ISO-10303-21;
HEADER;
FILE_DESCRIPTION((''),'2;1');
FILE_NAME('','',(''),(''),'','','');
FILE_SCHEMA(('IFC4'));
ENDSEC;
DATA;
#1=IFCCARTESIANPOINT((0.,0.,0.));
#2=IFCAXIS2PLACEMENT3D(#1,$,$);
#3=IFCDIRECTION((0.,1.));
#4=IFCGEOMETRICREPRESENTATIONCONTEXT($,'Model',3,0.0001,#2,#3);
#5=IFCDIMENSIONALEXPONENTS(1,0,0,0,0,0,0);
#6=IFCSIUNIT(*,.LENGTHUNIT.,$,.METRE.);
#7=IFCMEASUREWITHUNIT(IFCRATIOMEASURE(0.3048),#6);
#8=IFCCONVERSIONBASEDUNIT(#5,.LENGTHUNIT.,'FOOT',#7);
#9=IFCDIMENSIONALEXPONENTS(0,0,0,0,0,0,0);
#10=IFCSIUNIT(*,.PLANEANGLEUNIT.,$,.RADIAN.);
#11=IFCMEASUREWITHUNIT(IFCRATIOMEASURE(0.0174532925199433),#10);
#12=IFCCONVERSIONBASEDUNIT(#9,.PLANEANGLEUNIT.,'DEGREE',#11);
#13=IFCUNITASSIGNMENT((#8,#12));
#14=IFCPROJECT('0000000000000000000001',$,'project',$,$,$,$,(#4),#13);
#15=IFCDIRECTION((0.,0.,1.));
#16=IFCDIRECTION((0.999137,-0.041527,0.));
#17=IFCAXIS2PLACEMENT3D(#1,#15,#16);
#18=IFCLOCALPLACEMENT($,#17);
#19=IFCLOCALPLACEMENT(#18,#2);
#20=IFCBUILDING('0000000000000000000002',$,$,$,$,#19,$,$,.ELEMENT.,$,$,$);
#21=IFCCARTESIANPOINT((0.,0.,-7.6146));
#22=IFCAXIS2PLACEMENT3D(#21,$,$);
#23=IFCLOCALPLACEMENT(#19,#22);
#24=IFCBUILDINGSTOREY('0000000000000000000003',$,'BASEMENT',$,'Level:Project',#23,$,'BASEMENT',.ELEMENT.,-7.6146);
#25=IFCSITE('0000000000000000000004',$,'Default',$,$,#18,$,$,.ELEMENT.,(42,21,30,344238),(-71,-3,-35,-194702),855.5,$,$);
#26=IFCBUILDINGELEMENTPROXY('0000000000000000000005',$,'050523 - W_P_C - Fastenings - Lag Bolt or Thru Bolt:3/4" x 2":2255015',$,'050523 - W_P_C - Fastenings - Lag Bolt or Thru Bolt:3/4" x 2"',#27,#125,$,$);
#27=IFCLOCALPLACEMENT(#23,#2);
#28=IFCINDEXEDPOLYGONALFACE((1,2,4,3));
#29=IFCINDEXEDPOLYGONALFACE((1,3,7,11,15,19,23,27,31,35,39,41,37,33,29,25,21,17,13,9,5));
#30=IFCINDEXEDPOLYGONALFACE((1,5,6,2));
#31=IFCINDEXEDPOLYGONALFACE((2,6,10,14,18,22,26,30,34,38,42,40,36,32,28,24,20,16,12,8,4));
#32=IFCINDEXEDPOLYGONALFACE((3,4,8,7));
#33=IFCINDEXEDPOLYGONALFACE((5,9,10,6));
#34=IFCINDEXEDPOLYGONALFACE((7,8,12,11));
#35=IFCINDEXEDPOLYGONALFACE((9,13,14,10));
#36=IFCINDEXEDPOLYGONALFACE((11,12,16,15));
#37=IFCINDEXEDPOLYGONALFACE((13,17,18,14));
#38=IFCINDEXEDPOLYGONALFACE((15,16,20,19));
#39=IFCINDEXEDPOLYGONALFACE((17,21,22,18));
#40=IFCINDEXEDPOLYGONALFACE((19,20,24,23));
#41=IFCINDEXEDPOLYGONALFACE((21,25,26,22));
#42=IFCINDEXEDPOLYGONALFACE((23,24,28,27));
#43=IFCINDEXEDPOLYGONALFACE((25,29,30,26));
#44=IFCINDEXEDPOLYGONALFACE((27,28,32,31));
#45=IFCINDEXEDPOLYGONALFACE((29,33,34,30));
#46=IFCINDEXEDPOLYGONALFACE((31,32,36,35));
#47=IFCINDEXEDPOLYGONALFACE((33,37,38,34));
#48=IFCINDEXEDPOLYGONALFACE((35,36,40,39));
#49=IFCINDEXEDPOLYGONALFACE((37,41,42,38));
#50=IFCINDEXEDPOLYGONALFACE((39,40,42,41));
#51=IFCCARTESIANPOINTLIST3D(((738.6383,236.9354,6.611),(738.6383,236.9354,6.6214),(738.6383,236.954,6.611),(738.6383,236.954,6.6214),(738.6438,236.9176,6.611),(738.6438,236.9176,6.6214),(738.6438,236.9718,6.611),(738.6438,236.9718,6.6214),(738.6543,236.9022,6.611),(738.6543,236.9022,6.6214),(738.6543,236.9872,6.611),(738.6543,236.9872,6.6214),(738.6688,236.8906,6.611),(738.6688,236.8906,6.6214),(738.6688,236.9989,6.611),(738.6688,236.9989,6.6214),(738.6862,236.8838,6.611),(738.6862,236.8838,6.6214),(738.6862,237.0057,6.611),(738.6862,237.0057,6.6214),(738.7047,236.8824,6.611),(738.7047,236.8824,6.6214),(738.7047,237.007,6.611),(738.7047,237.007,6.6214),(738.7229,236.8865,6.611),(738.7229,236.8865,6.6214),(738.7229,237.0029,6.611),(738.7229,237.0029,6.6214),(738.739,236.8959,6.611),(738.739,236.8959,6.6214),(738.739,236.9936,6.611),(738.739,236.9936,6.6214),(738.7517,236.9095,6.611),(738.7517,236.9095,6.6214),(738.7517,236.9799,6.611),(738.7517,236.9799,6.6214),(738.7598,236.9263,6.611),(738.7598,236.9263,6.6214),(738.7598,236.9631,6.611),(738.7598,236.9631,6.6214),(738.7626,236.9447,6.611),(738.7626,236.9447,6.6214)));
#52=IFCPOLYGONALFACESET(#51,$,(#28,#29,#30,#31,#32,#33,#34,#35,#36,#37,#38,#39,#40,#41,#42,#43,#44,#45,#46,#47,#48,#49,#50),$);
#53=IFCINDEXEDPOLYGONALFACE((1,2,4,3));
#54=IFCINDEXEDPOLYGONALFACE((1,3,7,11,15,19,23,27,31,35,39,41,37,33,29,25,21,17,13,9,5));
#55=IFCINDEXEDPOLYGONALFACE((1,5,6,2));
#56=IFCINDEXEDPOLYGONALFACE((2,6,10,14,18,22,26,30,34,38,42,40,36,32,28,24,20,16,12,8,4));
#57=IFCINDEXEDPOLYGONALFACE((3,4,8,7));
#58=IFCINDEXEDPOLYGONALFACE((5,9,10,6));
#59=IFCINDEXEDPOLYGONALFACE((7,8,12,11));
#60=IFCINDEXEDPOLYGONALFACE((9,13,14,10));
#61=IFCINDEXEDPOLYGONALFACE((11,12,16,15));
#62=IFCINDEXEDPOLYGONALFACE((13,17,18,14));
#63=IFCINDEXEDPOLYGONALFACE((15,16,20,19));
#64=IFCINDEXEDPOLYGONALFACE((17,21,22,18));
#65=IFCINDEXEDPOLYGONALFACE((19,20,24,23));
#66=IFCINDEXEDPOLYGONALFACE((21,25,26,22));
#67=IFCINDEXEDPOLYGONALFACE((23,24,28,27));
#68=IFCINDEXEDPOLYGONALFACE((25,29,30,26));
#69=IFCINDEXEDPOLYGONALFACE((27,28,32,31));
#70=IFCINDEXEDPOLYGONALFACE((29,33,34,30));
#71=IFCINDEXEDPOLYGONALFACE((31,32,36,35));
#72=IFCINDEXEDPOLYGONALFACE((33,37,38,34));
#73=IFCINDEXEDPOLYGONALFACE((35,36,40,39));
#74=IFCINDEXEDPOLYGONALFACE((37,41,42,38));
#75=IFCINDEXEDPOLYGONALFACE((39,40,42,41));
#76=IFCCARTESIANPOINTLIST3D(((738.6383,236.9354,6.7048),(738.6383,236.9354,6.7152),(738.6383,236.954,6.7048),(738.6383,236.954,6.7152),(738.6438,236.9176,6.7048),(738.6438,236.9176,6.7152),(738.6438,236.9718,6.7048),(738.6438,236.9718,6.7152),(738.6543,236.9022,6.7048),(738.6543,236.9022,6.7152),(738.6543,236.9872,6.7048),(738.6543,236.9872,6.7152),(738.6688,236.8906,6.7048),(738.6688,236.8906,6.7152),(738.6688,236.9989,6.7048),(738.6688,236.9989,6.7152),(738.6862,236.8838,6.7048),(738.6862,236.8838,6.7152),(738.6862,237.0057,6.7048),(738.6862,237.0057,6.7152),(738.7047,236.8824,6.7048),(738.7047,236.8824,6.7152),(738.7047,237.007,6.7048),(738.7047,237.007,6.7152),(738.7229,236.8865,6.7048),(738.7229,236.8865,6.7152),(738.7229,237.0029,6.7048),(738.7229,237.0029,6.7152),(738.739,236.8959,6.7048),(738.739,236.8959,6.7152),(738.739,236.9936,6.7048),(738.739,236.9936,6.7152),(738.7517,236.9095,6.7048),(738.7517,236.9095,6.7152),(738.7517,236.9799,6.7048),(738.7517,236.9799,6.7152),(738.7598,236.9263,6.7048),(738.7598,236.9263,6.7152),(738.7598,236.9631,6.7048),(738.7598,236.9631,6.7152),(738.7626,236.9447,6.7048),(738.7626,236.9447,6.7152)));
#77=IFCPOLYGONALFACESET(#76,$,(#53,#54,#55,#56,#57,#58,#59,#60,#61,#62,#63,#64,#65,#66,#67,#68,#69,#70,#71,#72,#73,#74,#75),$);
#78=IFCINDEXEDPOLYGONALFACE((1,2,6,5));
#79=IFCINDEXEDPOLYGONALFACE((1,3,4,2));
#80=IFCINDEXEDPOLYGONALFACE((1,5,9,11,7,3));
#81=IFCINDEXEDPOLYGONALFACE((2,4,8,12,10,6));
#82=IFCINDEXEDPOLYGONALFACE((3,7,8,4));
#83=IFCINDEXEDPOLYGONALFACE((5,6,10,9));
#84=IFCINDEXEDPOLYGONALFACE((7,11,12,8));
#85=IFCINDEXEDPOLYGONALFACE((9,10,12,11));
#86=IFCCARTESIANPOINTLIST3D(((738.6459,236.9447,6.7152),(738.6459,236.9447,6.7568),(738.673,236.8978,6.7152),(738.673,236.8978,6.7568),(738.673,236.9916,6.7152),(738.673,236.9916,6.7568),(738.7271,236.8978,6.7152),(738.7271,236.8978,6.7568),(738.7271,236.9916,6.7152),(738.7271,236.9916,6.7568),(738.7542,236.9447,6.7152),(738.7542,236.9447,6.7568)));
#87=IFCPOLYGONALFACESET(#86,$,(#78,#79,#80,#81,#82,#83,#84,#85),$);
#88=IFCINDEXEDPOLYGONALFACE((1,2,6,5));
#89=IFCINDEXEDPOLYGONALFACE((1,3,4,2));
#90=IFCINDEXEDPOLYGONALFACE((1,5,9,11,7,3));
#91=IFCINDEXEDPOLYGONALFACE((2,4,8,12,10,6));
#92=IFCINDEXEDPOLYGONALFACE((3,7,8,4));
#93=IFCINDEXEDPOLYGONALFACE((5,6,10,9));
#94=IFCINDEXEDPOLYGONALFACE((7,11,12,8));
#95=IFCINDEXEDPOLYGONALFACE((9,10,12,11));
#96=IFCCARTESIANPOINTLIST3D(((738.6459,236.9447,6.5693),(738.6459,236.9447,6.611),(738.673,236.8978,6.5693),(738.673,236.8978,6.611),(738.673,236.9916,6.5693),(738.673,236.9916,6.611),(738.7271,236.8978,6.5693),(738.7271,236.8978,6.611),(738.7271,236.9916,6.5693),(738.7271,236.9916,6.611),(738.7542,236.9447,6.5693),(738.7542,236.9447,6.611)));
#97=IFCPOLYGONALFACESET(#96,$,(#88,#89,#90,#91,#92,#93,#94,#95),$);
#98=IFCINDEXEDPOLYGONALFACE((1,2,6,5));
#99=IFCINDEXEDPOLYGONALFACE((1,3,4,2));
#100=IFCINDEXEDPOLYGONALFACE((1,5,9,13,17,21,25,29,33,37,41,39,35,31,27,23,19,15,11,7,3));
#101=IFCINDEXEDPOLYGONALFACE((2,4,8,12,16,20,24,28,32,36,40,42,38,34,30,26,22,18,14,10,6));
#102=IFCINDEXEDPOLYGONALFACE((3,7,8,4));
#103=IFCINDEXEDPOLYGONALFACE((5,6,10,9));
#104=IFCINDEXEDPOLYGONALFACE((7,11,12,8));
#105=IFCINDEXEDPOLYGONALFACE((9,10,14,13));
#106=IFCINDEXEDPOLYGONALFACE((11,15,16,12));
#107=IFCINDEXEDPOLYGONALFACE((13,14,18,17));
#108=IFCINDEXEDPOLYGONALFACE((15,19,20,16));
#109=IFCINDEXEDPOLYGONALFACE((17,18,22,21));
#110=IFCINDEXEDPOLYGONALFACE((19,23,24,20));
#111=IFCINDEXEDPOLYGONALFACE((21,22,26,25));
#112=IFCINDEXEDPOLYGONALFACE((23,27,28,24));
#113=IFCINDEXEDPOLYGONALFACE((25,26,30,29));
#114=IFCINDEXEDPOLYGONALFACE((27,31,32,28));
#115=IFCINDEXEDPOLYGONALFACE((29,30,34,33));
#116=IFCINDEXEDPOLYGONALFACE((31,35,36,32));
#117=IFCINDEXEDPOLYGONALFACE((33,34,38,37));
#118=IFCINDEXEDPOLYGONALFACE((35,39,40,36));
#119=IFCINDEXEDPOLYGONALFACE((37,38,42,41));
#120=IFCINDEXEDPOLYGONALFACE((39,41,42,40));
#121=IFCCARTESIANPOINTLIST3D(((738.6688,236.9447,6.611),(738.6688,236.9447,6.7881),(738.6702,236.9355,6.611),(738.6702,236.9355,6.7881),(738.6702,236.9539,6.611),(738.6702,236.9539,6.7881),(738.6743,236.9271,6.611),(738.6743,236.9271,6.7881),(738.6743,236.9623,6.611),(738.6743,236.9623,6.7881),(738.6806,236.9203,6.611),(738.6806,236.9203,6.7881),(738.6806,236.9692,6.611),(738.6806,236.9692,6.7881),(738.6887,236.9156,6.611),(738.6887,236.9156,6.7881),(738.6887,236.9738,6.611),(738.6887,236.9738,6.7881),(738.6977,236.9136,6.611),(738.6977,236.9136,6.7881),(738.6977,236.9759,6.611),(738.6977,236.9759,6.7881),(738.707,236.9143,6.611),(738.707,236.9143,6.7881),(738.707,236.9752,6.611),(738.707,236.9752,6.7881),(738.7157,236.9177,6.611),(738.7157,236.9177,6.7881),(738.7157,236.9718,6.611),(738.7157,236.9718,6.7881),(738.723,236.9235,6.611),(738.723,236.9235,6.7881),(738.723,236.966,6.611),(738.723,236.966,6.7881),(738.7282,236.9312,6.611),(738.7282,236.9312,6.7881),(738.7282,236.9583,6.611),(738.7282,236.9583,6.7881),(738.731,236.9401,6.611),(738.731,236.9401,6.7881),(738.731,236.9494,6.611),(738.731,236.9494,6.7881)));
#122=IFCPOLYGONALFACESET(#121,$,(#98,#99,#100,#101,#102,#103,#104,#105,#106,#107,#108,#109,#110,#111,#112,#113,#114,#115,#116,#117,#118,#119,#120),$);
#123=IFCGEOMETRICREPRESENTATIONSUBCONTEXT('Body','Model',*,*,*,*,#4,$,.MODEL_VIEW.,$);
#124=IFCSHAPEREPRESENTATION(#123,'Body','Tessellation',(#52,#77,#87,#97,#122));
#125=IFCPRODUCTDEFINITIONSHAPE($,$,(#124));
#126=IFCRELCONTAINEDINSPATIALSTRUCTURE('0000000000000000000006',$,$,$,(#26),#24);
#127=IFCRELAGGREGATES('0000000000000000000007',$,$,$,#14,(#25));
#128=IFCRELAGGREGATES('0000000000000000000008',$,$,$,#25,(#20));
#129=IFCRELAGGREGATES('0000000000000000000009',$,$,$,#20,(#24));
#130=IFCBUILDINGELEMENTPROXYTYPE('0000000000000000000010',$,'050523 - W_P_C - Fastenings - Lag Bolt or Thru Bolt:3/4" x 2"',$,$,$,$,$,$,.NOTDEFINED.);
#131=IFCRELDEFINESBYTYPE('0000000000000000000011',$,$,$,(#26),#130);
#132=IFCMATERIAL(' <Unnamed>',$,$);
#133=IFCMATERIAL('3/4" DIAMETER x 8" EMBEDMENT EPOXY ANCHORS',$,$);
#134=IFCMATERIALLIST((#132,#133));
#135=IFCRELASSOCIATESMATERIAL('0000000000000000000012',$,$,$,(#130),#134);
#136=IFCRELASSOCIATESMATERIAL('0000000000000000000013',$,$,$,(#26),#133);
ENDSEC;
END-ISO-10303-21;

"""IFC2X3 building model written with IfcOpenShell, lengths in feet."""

from ifc_helpers import new_model, entity, si_unit, converted_unit, direction, frame, frame_2d, origin, place, context, subcontext, project, spatial, polyline, circle, outline, extrude, source, transform, mapped, material, material_list, type_object, type_shapes, element, save


model = new_model("IFC2X3")

# Units and contexts
model_context = context("Model", 3, precision=0.0001, world=origin(), true_north=direction((0.0, 1.0)))
body_context = subcontext(model_context, "Body", "Model", "MODEL_VIEW")
ifc_project = project(units=[converted_unit("LENGTHUNIT", "FOOT", entity("IfcRatioMeasure", 0.3048), si_unit("LENGTHUNIT", "METRE"), dimensions=[1, 0, 0, 0, 0, 0, 0]), converted_unit("PLANEANGLEUNIT", "DEGREE", entity("IfcRatioMeasure", 0.0174532925199433), si_unit("PLANEANGLEUNIT", "RADIAN"), dimensions=[0, 0, 0, 0, 0, 0, 0])], contexts=[model_context])

# Site, building, storey
site_placement = place(None, frame((0.0, 0.0, 0.0), z_axis=(0.0, 0.0, 1.0), x_axis=(0.999137, -0.041527, 0.0)))
site = spatial("IfcSite", under=ifc_project, at=site_placement, Name="Default", CompositionType="ELEMENT", RefLatitude=(42, 21, 30, 344238), RefLongitude=(-71, -3, -35, -194702), RefElevation=855.5)
building_placement = place(site_placement, origin())
building = spatial("IfcBuilding", under=site, at=building_placement, CompositionType="ELEMENT")
storey_placement = place(building_placement, frame((0.0, 0.0, -7.6146)))
storey = spatial("IfcBuildingStorey", under=building, at=storey_placement, Name="BASEMENT", ObjectType="Level:Project", LongName="BASEMENT", CompositionType="ELEMENT", Elevation=-7.6146)

# Building element proxy
ifc_material_1 = material(Name=" <Unnamed>")
ifc_material_2 = material(Name="3/4\" DIAMETER x 8\" EMBEDMENT EPOXY ANCHORS")
ifc_material_list_1 = material_list([ifc_material_1, ifc_material_2])
building_element_proxy_type_1 = type_object("IfcBuildingElementProxyType", Name="050523 - W_P_C - Fastenings - Lag Bolt or Thru Bolt:3/4\" x 2\"", PredefinedType="NOTDEFINED", material=ifc_material_list_1)
shared_shape_1 = source(origin(), body_context, "Body", "SweptSolid", [
    extrude(circle(Radius=0.0625, at=frame_2d((0.0, 0.0), x_axis=(1.0, 0.0))), frame((0.0, 0.0, 0.0), z_axis=(0.0, 0.0, 1.0), x_axis=(0.0, -1.0, 0.0)), (0.0, 0.0, 1.0), 0.0104),
    extrude(circle(Radius=0.0625, at=frame_2d((0.0, 0.0), x_axis=(1.0, 0.0))), frame((0.0, 0.0, -0.0938), z_axis=(0.0, 0.0, 1.0), x_axis=(0.0, -1.0, 0.0)), (0.0, 0.0, 1.0), 0.0104),
    extrude(outline(polyline([(-0.0271, -0.0469), (0.0271, -0.0469), (0.0541, 0.0), (0.0271, 0.0469), (-0.0271, 0.0469), (-0.0541, 0.0), (-0.0271, -0.0469)])), frame((0.0, 0.0, -0.1354), z_axis=(0.0, 0.0, 1.0), x_axis=(0.866025, -0.5, 0.0)), (0.0, 0.0, 1.0), 0.0417),
    extrude(outline(polyline([(-0.0271, -0.0469), (0.0271, -0.0469), (0.0541, 0.0), (0.0271, 0.0469), (-0.0271, 0.0469), (-0.0541, 0.0), (-0.0271, -0.0469)])), frame((0.0, 0.0, 0.0104), z_axis=(0.0, 0.0, 1.0), x_axis=(0.0, -1.0, 0.0)), (0.0, 0.0, 1.0), 0.0417),
    extrude(circle(Radius=0.0312, at=frame_2d((0.0, 0.0), x_axis=(1.0, 0.0))), frame((0.0, 0.0, -0.1667), z_axis=(0.0, 0.0, 1.0), x_axis=(0.0, 1.0, 0.0)), (0.0, 0.0, 1.0), 0.1771),
])
type_shapes(building_element_proxy_type_1, [shared_shape_1])
for number, where, z_axis, x_axis, name in (
    (1, (738.7001, 236.9447, 6.6214), (0.0, 0.0, -1.0), (0.0, -1.0, 0.0), "050523 - W_P_C - Fastenings - Lag Bolt or Thru Bolt:3/4\" x 2\":2255015"),
):
    element("IfcBuildingElementProxy", number, at=place(storey_placement, frame(where, z_axis=z_axis, x_axis=x_axis)), inside=storey, type_object=building_element_proxy_type_1, material=ifc_material_2, Name=name, ObjectType="050523 - W_P_C - Fastenings - Lag Bolt or Thru Bolt:3/4\" x 2\"", context=body_context, shape_type="MappedRepresentation", body=[
        mapped(shared_shape_1, transform((0.0, 0.0, 0.0), scale=1.0)),
    ])

save(model, "model.ifc")
